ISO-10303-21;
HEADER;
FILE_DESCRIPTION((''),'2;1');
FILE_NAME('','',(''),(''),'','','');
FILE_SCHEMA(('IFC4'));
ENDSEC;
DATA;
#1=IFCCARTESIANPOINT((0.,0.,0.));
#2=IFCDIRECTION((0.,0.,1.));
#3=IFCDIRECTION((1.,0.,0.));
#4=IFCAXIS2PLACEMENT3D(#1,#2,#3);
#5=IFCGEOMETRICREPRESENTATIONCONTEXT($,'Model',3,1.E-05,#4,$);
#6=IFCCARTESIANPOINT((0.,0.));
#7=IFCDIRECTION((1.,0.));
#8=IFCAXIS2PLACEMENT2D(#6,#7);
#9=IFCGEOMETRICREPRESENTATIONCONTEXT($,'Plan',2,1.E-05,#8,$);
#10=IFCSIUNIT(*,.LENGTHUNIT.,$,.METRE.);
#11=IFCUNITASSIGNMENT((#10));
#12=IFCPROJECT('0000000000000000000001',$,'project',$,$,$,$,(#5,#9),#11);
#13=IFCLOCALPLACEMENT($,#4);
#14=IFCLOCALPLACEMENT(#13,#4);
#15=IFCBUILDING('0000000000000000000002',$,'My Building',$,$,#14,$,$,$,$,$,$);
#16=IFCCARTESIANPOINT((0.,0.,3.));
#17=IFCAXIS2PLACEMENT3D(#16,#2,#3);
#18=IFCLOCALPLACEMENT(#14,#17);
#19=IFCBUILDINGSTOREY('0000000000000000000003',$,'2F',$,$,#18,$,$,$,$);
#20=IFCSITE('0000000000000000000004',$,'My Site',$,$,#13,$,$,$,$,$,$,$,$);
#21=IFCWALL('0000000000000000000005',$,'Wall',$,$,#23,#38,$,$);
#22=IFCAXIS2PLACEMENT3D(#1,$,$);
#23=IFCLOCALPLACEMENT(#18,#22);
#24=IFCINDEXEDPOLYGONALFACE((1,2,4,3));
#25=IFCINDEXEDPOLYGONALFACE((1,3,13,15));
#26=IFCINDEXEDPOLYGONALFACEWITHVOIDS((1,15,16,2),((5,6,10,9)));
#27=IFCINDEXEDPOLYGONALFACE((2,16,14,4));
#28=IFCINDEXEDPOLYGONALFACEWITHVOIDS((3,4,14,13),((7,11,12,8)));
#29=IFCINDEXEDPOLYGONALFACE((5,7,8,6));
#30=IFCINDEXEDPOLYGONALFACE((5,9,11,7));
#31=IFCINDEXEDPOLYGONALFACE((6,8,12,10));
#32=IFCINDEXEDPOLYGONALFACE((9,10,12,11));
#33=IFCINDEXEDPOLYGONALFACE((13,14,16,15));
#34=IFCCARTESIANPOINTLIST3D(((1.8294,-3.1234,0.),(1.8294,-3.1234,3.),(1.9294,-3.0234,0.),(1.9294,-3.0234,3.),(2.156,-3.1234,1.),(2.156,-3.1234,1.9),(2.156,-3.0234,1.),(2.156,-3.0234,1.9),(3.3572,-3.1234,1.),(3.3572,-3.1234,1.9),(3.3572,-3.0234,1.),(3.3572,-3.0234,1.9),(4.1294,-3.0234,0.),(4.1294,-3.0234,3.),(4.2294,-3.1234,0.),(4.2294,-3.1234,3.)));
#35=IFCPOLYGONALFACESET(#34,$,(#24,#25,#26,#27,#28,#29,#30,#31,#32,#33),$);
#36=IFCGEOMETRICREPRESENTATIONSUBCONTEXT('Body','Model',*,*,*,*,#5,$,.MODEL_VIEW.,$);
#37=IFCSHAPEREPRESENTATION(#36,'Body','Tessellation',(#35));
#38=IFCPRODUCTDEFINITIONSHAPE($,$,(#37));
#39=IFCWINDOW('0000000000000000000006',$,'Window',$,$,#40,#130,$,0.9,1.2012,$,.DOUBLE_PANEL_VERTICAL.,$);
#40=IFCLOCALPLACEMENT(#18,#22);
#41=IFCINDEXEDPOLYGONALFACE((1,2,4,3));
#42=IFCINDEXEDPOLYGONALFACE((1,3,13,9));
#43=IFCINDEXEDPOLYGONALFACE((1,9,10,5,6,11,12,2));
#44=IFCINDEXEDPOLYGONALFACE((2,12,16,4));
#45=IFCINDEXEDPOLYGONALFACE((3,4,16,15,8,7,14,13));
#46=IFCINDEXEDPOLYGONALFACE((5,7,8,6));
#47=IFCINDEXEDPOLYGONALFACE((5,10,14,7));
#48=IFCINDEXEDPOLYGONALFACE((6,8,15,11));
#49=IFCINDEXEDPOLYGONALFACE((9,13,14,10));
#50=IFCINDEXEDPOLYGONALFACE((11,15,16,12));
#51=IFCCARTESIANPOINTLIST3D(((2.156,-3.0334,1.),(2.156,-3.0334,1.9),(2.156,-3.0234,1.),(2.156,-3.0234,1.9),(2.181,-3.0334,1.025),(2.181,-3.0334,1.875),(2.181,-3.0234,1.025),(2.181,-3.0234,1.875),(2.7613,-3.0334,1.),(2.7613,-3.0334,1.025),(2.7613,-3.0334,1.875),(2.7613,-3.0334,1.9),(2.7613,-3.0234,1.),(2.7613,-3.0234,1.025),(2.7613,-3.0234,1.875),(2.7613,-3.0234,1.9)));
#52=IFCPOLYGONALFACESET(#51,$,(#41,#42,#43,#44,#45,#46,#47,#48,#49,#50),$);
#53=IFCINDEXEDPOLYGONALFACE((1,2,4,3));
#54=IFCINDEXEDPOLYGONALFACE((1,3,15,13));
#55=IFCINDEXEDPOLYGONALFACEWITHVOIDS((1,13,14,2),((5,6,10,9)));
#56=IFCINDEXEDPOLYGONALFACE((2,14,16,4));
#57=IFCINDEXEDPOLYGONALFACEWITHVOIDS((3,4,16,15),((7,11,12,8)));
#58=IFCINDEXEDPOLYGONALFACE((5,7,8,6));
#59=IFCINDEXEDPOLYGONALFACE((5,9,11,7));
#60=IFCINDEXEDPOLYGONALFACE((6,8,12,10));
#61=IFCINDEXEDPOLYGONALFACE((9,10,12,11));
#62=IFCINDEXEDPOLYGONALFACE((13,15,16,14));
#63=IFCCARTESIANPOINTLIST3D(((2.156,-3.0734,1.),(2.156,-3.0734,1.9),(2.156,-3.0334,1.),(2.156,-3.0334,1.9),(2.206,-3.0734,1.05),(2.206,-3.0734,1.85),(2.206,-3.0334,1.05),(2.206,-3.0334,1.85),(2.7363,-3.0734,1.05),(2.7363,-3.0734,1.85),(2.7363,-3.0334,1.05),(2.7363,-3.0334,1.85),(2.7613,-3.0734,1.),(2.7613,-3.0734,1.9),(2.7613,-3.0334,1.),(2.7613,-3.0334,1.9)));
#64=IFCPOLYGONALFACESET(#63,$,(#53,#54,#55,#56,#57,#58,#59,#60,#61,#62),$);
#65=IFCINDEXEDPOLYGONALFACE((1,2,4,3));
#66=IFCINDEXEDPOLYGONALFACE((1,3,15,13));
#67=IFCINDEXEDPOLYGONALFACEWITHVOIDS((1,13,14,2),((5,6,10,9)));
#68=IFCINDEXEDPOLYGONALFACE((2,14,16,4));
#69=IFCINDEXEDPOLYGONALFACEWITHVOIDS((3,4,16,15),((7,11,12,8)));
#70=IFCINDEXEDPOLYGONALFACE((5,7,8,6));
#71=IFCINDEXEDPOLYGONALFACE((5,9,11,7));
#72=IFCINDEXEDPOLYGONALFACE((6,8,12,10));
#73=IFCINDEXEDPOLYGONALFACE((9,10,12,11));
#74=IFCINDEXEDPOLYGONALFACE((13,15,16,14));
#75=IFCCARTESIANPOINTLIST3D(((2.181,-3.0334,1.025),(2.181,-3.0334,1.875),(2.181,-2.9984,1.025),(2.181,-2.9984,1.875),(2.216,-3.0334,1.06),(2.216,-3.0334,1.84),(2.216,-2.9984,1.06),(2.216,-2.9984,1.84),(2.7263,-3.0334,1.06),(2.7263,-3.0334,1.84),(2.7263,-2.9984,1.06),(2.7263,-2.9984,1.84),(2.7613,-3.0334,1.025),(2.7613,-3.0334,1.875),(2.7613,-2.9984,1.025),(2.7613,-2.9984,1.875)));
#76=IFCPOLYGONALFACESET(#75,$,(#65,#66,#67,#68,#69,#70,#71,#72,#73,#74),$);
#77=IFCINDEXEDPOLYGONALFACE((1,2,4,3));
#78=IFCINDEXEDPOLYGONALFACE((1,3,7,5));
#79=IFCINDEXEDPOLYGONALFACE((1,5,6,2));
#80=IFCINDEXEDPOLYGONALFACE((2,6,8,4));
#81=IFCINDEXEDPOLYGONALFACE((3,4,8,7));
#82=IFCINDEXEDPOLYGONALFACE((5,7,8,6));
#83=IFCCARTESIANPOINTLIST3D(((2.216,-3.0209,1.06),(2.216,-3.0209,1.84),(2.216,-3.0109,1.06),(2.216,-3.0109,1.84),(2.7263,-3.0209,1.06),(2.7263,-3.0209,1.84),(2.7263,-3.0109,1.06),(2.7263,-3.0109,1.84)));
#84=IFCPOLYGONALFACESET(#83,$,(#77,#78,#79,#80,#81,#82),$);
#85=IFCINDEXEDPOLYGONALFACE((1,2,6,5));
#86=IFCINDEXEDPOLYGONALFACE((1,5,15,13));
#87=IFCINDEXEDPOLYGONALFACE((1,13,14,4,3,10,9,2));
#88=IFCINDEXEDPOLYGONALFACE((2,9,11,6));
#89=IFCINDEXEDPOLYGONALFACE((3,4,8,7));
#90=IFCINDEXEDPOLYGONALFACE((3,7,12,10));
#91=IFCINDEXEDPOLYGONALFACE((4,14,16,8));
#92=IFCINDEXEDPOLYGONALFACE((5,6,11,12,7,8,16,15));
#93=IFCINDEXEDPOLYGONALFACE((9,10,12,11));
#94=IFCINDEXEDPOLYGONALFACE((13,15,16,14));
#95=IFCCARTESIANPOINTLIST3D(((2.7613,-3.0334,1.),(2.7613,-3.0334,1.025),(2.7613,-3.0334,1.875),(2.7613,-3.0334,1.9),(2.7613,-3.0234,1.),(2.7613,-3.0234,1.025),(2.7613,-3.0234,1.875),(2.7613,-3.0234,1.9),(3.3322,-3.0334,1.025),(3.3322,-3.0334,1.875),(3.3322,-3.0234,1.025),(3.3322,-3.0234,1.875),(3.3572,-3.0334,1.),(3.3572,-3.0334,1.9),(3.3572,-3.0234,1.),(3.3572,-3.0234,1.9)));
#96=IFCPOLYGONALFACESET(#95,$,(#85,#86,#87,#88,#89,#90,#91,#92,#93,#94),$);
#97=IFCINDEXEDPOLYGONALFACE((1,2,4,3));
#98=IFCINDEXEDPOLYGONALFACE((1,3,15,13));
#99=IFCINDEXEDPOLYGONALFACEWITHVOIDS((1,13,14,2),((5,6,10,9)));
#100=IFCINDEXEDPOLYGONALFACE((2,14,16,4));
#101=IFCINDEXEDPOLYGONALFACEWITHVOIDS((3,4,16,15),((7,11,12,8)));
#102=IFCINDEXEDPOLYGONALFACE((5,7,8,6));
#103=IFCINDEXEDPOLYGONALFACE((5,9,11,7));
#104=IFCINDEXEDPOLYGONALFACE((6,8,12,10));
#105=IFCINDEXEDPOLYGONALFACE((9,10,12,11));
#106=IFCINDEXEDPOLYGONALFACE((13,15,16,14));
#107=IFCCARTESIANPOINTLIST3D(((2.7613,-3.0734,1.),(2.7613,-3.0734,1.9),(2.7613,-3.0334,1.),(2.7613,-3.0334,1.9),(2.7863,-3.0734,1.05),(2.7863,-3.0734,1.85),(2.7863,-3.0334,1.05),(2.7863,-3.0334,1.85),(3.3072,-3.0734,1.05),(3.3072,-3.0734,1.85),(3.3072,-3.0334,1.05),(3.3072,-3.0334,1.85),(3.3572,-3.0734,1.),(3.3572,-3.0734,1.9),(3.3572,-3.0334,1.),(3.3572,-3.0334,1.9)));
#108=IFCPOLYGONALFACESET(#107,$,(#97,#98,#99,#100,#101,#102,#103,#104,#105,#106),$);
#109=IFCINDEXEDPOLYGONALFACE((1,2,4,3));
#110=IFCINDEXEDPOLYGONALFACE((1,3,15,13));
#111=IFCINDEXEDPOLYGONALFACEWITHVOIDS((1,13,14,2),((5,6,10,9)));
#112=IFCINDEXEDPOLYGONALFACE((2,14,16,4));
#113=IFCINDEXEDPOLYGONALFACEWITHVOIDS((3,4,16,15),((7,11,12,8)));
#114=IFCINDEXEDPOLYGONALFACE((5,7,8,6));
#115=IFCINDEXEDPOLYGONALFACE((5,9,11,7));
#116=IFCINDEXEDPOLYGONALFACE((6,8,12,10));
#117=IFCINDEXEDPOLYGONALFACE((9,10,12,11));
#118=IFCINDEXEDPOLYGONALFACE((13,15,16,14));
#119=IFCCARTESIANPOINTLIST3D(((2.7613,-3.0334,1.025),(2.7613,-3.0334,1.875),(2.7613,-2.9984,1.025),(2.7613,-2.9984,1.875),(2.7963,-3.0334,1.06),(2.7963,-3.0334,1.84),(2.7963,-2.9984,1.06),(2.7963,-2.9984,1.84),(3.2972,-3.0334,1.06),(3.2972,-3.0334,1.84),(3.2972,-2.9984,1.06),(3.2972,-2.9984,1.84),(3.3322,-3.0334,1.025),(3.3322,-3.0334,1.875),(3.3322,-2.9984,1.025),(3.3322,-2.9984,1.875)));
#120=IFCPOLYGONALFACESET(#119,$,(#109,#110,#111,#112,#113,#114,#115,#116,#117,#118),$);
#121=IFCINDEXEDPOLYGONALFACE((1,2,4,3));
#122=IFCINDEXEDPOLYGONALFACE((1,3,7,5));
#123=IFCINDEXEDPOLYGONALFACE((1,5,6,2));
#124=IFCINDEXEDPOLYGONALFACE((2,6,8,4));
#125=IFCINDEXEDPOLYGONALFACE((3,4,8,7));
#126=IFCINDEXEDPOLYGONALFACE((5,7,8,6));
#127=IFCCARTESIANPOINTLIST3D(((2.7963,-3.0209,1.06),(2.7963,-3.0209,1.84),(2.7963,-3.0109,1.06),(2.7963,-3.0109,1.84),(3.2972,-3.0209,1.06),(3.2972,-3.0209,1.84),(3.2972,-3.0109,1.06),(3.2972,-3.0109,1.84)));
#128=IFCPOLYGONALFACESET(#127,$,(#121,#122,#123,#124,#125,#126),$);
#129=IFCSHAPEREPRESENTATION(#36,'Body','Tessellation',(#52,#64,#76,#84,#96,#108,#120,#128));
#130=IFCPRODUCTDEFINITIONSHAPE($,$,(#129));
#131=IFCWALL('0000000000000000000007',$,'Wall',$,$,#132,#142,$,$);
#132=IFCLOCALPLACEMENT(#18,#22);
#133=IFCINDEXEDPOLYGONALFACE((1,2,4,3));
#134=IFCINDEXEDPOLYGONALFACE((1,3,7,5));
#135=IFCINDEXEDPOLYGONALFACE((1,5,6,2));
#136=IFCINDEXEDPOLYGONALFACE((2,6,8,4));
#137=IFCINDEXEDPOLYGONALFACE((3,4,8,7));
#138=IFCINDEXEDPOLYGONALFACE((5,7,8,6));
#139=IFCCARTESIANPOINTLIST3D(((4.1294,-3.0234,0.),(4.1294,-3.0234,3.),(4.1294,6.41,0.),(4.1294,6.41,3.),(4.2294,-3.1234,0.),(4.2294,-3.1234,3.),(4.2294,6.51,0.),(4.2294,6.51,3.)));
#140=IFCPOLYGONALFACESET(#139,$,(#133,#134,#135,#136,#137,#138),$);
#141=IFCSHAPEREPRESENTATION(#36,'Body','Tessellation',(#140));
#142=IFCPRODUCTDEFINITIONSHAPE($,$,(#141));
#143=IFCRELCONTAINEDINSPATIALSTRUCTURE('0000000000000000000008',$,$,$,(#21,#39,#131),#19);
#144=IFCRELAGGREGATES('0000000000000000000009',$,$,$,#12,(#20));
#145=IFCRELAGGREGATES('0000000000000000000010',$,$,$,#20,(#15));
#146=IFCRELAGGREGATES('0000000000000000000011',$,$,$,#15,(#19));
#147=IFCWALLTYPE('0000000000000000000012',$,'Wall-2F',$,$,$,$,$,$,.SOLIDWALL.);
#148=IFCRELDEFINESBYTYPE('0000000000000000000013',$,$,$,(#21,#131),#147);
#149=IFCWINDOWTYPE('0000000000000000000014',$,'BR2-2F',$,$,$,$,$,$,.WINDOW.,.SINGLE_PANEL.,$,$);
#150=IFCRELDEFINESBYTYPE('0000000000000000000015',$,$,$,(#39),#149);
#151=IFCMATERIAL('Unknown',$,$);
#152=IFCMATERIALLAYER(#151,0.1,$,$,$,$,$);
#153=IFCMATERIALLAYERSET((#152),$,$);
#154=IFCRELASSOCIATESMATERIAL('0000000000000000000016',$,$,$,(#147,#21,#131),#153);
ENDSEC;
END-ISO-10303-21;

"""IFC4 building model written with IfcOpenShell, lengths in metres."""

from ifc_helpers import new_model, entity, si_unit, frame, origin_with_axes, origin_2d_with_axis, place, context, subcontext, project, spatial, line, indexed_curve, outline, extrude, shape, source, transform, mapped, material, layer, layer_set, layer_usage, type_object, type_shapes, element, fill, save


model = new_model("IFC4")

# Units and contexts
model_context = context("Model", 3, precision=1e-05, world=origin_with_axes())
plan_context = context("Plan", 2, precision=1e-05, world=origin_2d_with_axis())
body_context_1 = subcontext(model_context, "Body", "Model", "MODEL_VIEW")
body_context_2 = subcontext(plan_context, "Body", "Plan", "PLAN_VIEW")
ifc_project = project(units=[si_unit("LENGTHUNIT", "METRE")], contexts=[model_context, plan_context])

# Site, building, storey
site_placement = place(None, origin_with_axes())
site = spatial("IfcSite", under=ifc_project, at=site_placement, Name="My Site")
building_placement = place(site_placement, origin_with_axes())
building = spatial("IfcBuilding", under=site, at=building_placement, Name="My Building")
storey_placement = place(building_placement, frame((0.0, 0.0, 3.0), z_axis=(0.0, 0.0, 1.0), x_axis=(1.0, 0.0, 0.0)))
storey = spatial("IfcBuildingStorey", under=building, at=storey_placement, Name="2F")

# Shared definitions
ifc_material = material(Name="Unknown")
ifc_layer_1 = layer(ifc_material, 0.1)
ifc_layer_set_1 = layer_set([ifc_layer_1])
wall_type_1 = type_object("IfcWallType", Name="Wall-2F", PredefinedType="SOLIDWALL", material=ifc_layer_set_1)

# Wall, opening, window
ifc_layer_usage_1 = layer_usage(ifc_layer_set_1, "AXIS2", "POSITIVE", 0.0)
wall_1_placement = place(storey_placement, frame((1.8294, -3.1234, 0.0), z_axis=(0.0, 0.0, 1.0), x_axis=(1.0, 0.0, 0.0)))
wall_1 = element("IfcWall", 1, at=wall_1_placement, inside=storey, type_object=wall_type_1, material=ifc_layer_usage_1, Name="Wall", context=body_context_1, shape_type="SweptSolid", body=[
    extrude(outline(indexed_curve([(0.0, 0.0), (0.1, 0.1), (2.3, 0.1), (2.4, 0.0)], segments=[line(1, 2, 3, 4, 1)])), origin_with_axes(), (0.0, 0.0, 1.0), 3.0),
])
shared_shape_1 = source(origin_with_axes(), body_context_1, "Body", "SweptSolid", [
    extrude(outline(indexed_curve([(0.0, 0.0), (1.2012, 0.0), (1.2012, 0.9), (0.0, 0.9)], segments=[line(1, 2, 3, 4, 1)])), frame((0.0, -0.6, 0.0), z_axis=(0.0, -1.0, 0.0), x_axis=(1.0, 0.0, 0.0)), (0.0, 0.0, -1.0), 1.2),
])
opening_1_placement = place(wall_1_placement, frame((0.3266, 0.0, 1.0), z_axis=(0.0, 0.0, 1.0), x_axis=(1.0, 0.0, 0.0)))
opening_1 = element("IfcOpeningElement", 2, at=opening_1_placement, cuts=wall_1, PredefinedType="OPENING", context=body_context_1, shape_type="MappedRepresentation", body=[
    mapped(shared_shape_1, transform((0.0, 0.0, 0.0), x_axis=(1.0, 0.0, 0.0), y_axis=(0.0, 1.0, 0.0), z_axis=(0.0, 0.0, 1.0), scale=1.0)),
])
window_type_1 = type_object("IfcWindowType", Name="BR2-2F", PartitioningType="SINGLE_PANEL", PredefinedType="WINDOW")
shared_shape_2 = source(origin_with_axes(), body_context_1, "Body", "SweptSolid", [
    extrude(outline(indexed_curve([(0.6053, 0.0), (0.0, 0.0), (0.0, 0.9), (0.6053, 0.9), (0.6053, 0.875), (0.025, 0.875), (0.025, 0.025), (0.6053, 0.025)], segments=[line(1, 2, 3, 4, 5, 6, 7, 8, 1)])), frame((0.0, 0.09, 0.0), z_axis=(0.0, -1.0, 0.0), x_axis=(1.0, 0.0, 0.0)), (0.0, 0.0, -1.0), 0.01),
    extrude(outline(indexed_curve([(0.0, 0.0), (0.6053, 0.0), (0.6053, 0.9), (0.0, 0.9)], segments=[line(1, 2, 3, 4, 1)]), holes=[indexed_curve([(0.05, 0.05), (0.5803, 0.05), (0.5803, 0.85), (0.05, 0.85)], segments=[line(1, 2, 3, 4, 1)])]), frame((0.0, 0.05, 0.0), z_axis=(0.0, -1.0, 0.0), x_axis=(1.0, 0.0, 0.0)), (0.0, 0.0, -1.0), 0.04),
    extrude(outline(indexed_curve([(0.0, 0.0), (0.5803, 0.0), (0.5803, 0.85), (0.0, 0.85)], segments=[line(1, 2, 3, 4, 1)]), holes=[indexed_curve([(0.035, 0.035), (0.5453, 0.035), (0.5453, 0.815), (0.035, 0.815)], segments=[line(1, 2, 3, 4, 1)])]), frame((0.025, 0.09, 0.025), z_axis=(0.0, -1.0, 0.0), x_axis=(1.0, 0.0, 0.0)), (0.0, 0.0, -1.0), 0.035),
    extrude(outline(indexed_curve([(0.035, 0.035), (0.5453, 0.035), (0.5453, 0.815), (0.035, 0.815)], segments=[line(1, 2, 3, 4, 1)])), frame((0.025, 0.1025, 0.025), z_axis=(0.0, -1.0, 0.0), x_axis=(1.0, 0.0, 0.0)), (0.0, 0.0, -1.0), 0.01),
    extrude(outline(indexed_curve([(0.0, 0.9), (0.5958, 0.9), (0.5958, 0.0), (0.0, 0.0), (0.0, 0.025), (0.5708, 0.025), (0.5708, 0.875), (0.0, 0.875)], segments=[line(1, 2, 3, 4, 5, 6, 7, 8, 1)])), frame((0.6053, 0.09, 0.0), z_axis=(0.0, -1.0, 0.0), x_axis=(1.0, 0.0, 0.0)), (0.0, 0.0, -1.0), 0.01),
    extrude(outline(indexed_curve([(0.0, 0.0), (0.5958, 0.0), (0.5958, 0.9), (0.0, 0.9)], segments=[line(1, 2, 3, 4, 1)]), holes=[indexed_curve([(0.025, 0.05), (0.5458, 0.05), (0.5458, 0.85), (0.025, 0.85)], segments=[line(1, 2, 3, 4, 1)])]), frame((0.6053, 0.05, 0.0), z_axis=(0.0, -1.0, 0.0), x_axis=(1.0, 0.0, 0.0)), (0.0, 0.0, -1.0), 0.04),
    extrude(outline(indexed_curve([(0.0, 0.0), (0.5708, 0.0), (0.5708, 0.85), (0.0, 0.85)], segments=[line(1, 2, 3, 4, 1)]), holes=[indexed_curve([(0.035, 0.035), (0.5358, 0.035), (0.5358, 0.815), (0.035, 0.815)], segments=[line(1, 2, 3, 4, 1)])]), frame((0.6053, 0.09, 0.025), z_axis=(0.0, -1.0, 0.0), x_axis=(1.0, 0.0, 0.0)), (0.0, 0.0, -1.0), 0.035),
    extrude(outline(indexed_curve([(0.035, 0.035), (0.5358, 0.035), (0.5358, 0.815), (0.035, 0.815)], segments=[line(1, 2, 3, 4, 1)])), frame((0.6053, 0.1025, 0.025), z_axis=(0.0, -1.0, 0.0), x_axis=(1.0, 0.0, 0.0)), (0.0, 0.0, -1.0), 0.01),
])
shared_shape_3 = source(origin_with_axes(), body_context_2, "Body", "Curve2D", [
    entity("IfcIndexedPolyCurve", entity("IfcCartesianPointList2D", [[0.05, 0.05], [0.5803, 0.05]])),
    entity("IfcIndexedPolyCurve", entity("IfcCartesianPointList2D", [[0.0, 0.1], [0.025, 0.1], [0.025, 0.09], [0.05, 0.09], [0.05, 0.05], [0.0, 0.05]]), [entity("IfcLineIndex", [1, 2, 3, 4, 5, 6, 1])]),
    entity("IfcIndexedPolyCurve", entity("IfcCartesianPointList2D", [[0.6053, 0.1], [0.6053, 0.1], [0.6053, 0.09], [0.5803, 0.09], [0.5803, 0.05], [0.6053, 0.05]])),
    entity("IfcIndexedPolyCurve", entity("IfcCartesianPointList2D", [[0.025, 0.09], [0.06, 0.09], [0.06, 0.125], [0.025, 0.125]]), [entity("IfcLineIndex", [1, 2, 3, 4, 1])]),
    entity("IfcIndexedPolyCurve", entity("IfcCartesianPointList2D", [[0.6053, 0.09], [0.5703, 0.09], [0.5703, 0.125], [0.6053, 0.125]]), [entity("IfcLineIndex", [1, 2, 3, 4, 1])]),
    entity("IfcIndexedPolyCurve", entity("IfcCartesianPointList2D", [[0.06, 0.09], [0.5703, 0.09]])),
    entity("IfcIndexedPolyCurve", entity("IfcCartesianPointList2D", [[0.06, 0.125], [0.5703, 0.125]])),
    entity("IfcIndexedPolyCurve", entity("IfcCartesianPointList2D", [[0.06, 0.1075], [0.5703, 0.1075]])),
    entity("IfcIndexedPolyCurve", entity("IfcCartesianPointList2D", [[0.6303, 0.05], [1.1512, 0.05]])),
    entity("IfcIndexedPolyCurve", entity("IfcCartesianPointList2D", [[0.6053, 0.1], [0.6053, 0.1], [0.6053, 0.09], [0.6303, 0.09], [0.6303, 0.05], [0.6053, 0.05]])),
    entity("IfcIndexedPolyCurve", entity("IfcCartesianPointList2D", [[1.2012, 0.1], [1.1762, 0.1], [1.1762, 0.09], [1.1512, 0.09], [1.1512, 0.05], [1.2012, 0.05]]), [entity("IfcLineIndex", [1, 2, 3, 4, 5, 6, 1])]),
    entity("IfcIndexedPolyCurve", entity("IfcCartesianPointList2D", [[0.6053, 0.09], [0.6403, 0.09], [0.6403, 0.125], [0.6053, 0.125]]), [entity("IfcLineIndex", [1, 2, 3, 4, 1])]),
    entity("IfcIndexedPolyCurve", entity("IfcCartesianPointList2D", [[1.1762, 0.09], [1.1412, 0.09], [1.1412, 0.125], [1.1762, 0.125]]), [entity("IfcLineIndex", [1, 2, 3, 4, 1])]),
    entity("IfcIndexedPolyCurve", entity("IfcCartesianPointList2D", [[0.6403, 0.09], [1.1412, 0.09]])),
    entity("IfcIndexedPolyCurve", entity("IfcCartesianPointList2D", [[0.6403, 0.125], [1.1412, 0.125]])),
    entity("IfcIndexedPolyCurve", entity("IfcCartesianPointList2D", [[0.6403, 0.1075], [1.1412, 0.1075]])),
])
type_shapes(window_type_1, [shared_shape_2, shared_shape_3])
window_1_placement = place(opening_1_placement, origin_with_axes())
window_1 = element("IfcWindow", 3, at=window_1_placement, inside=storey, type_object=window_type_1, Name="Window", OverallHeight=0.9, OverallWidth=1.2012, PartitioningType="DOUBLE_PANEL_VERTICAL", shapes=[
    shape(body_context_1, "Body", "MappedRepresentation", [mapped(shared_shape_2, transform((0.0, 0.0, 0.0), x_axis=(1.0, 0.0, 0.0), y_axis=(0.0, 1.0, 0.0), z_axis=(0.0, 0.0, 1.0), scale=1.0))]),
    shape(body_context_2, "Body", "MappedRepresentation", [mapped(shared_shape_3, transform((0.0, 0.0, 0.0), x_axis=(1.0, 0.0, 0.0), y_axis=(0.0, 1.0, 0.0), z_axis=(0.0, 0.0, 1.0), scale=1.0))]),
])
fill(opening_1, window_1)

# Wall
ifc_layer_usage_2 = layer_usage(ifc_layer_set_1, "AXIS2", "POSITIVE", 0.0)
wall_2_placement = place(storey_placement, frame((4.2294, -3.1234, 0.0), z_axis=(0.0, 0.0, 1.0), x_axis=(0.0, 1.0, 0.0)))
element("IfcWall", 4, at=wall_2_placement, inside=storey, type_object=wall_type_1, material=ifc_layer_usage_2, Name="Wall", context=body_context_1, shape_type="SweptSolid", body=[
    extrude(outline(indexed_curve([(0.0, 0.0), (0.1, 0.1), (9.5334, 0.1), (9.6334, 0.0)], segments=[line(1, 2, 3, 4, 1)])), origin_with_axes(), (0.0, 0.0, 1.0), 3.0),
])

save(model, "model.ifc")
